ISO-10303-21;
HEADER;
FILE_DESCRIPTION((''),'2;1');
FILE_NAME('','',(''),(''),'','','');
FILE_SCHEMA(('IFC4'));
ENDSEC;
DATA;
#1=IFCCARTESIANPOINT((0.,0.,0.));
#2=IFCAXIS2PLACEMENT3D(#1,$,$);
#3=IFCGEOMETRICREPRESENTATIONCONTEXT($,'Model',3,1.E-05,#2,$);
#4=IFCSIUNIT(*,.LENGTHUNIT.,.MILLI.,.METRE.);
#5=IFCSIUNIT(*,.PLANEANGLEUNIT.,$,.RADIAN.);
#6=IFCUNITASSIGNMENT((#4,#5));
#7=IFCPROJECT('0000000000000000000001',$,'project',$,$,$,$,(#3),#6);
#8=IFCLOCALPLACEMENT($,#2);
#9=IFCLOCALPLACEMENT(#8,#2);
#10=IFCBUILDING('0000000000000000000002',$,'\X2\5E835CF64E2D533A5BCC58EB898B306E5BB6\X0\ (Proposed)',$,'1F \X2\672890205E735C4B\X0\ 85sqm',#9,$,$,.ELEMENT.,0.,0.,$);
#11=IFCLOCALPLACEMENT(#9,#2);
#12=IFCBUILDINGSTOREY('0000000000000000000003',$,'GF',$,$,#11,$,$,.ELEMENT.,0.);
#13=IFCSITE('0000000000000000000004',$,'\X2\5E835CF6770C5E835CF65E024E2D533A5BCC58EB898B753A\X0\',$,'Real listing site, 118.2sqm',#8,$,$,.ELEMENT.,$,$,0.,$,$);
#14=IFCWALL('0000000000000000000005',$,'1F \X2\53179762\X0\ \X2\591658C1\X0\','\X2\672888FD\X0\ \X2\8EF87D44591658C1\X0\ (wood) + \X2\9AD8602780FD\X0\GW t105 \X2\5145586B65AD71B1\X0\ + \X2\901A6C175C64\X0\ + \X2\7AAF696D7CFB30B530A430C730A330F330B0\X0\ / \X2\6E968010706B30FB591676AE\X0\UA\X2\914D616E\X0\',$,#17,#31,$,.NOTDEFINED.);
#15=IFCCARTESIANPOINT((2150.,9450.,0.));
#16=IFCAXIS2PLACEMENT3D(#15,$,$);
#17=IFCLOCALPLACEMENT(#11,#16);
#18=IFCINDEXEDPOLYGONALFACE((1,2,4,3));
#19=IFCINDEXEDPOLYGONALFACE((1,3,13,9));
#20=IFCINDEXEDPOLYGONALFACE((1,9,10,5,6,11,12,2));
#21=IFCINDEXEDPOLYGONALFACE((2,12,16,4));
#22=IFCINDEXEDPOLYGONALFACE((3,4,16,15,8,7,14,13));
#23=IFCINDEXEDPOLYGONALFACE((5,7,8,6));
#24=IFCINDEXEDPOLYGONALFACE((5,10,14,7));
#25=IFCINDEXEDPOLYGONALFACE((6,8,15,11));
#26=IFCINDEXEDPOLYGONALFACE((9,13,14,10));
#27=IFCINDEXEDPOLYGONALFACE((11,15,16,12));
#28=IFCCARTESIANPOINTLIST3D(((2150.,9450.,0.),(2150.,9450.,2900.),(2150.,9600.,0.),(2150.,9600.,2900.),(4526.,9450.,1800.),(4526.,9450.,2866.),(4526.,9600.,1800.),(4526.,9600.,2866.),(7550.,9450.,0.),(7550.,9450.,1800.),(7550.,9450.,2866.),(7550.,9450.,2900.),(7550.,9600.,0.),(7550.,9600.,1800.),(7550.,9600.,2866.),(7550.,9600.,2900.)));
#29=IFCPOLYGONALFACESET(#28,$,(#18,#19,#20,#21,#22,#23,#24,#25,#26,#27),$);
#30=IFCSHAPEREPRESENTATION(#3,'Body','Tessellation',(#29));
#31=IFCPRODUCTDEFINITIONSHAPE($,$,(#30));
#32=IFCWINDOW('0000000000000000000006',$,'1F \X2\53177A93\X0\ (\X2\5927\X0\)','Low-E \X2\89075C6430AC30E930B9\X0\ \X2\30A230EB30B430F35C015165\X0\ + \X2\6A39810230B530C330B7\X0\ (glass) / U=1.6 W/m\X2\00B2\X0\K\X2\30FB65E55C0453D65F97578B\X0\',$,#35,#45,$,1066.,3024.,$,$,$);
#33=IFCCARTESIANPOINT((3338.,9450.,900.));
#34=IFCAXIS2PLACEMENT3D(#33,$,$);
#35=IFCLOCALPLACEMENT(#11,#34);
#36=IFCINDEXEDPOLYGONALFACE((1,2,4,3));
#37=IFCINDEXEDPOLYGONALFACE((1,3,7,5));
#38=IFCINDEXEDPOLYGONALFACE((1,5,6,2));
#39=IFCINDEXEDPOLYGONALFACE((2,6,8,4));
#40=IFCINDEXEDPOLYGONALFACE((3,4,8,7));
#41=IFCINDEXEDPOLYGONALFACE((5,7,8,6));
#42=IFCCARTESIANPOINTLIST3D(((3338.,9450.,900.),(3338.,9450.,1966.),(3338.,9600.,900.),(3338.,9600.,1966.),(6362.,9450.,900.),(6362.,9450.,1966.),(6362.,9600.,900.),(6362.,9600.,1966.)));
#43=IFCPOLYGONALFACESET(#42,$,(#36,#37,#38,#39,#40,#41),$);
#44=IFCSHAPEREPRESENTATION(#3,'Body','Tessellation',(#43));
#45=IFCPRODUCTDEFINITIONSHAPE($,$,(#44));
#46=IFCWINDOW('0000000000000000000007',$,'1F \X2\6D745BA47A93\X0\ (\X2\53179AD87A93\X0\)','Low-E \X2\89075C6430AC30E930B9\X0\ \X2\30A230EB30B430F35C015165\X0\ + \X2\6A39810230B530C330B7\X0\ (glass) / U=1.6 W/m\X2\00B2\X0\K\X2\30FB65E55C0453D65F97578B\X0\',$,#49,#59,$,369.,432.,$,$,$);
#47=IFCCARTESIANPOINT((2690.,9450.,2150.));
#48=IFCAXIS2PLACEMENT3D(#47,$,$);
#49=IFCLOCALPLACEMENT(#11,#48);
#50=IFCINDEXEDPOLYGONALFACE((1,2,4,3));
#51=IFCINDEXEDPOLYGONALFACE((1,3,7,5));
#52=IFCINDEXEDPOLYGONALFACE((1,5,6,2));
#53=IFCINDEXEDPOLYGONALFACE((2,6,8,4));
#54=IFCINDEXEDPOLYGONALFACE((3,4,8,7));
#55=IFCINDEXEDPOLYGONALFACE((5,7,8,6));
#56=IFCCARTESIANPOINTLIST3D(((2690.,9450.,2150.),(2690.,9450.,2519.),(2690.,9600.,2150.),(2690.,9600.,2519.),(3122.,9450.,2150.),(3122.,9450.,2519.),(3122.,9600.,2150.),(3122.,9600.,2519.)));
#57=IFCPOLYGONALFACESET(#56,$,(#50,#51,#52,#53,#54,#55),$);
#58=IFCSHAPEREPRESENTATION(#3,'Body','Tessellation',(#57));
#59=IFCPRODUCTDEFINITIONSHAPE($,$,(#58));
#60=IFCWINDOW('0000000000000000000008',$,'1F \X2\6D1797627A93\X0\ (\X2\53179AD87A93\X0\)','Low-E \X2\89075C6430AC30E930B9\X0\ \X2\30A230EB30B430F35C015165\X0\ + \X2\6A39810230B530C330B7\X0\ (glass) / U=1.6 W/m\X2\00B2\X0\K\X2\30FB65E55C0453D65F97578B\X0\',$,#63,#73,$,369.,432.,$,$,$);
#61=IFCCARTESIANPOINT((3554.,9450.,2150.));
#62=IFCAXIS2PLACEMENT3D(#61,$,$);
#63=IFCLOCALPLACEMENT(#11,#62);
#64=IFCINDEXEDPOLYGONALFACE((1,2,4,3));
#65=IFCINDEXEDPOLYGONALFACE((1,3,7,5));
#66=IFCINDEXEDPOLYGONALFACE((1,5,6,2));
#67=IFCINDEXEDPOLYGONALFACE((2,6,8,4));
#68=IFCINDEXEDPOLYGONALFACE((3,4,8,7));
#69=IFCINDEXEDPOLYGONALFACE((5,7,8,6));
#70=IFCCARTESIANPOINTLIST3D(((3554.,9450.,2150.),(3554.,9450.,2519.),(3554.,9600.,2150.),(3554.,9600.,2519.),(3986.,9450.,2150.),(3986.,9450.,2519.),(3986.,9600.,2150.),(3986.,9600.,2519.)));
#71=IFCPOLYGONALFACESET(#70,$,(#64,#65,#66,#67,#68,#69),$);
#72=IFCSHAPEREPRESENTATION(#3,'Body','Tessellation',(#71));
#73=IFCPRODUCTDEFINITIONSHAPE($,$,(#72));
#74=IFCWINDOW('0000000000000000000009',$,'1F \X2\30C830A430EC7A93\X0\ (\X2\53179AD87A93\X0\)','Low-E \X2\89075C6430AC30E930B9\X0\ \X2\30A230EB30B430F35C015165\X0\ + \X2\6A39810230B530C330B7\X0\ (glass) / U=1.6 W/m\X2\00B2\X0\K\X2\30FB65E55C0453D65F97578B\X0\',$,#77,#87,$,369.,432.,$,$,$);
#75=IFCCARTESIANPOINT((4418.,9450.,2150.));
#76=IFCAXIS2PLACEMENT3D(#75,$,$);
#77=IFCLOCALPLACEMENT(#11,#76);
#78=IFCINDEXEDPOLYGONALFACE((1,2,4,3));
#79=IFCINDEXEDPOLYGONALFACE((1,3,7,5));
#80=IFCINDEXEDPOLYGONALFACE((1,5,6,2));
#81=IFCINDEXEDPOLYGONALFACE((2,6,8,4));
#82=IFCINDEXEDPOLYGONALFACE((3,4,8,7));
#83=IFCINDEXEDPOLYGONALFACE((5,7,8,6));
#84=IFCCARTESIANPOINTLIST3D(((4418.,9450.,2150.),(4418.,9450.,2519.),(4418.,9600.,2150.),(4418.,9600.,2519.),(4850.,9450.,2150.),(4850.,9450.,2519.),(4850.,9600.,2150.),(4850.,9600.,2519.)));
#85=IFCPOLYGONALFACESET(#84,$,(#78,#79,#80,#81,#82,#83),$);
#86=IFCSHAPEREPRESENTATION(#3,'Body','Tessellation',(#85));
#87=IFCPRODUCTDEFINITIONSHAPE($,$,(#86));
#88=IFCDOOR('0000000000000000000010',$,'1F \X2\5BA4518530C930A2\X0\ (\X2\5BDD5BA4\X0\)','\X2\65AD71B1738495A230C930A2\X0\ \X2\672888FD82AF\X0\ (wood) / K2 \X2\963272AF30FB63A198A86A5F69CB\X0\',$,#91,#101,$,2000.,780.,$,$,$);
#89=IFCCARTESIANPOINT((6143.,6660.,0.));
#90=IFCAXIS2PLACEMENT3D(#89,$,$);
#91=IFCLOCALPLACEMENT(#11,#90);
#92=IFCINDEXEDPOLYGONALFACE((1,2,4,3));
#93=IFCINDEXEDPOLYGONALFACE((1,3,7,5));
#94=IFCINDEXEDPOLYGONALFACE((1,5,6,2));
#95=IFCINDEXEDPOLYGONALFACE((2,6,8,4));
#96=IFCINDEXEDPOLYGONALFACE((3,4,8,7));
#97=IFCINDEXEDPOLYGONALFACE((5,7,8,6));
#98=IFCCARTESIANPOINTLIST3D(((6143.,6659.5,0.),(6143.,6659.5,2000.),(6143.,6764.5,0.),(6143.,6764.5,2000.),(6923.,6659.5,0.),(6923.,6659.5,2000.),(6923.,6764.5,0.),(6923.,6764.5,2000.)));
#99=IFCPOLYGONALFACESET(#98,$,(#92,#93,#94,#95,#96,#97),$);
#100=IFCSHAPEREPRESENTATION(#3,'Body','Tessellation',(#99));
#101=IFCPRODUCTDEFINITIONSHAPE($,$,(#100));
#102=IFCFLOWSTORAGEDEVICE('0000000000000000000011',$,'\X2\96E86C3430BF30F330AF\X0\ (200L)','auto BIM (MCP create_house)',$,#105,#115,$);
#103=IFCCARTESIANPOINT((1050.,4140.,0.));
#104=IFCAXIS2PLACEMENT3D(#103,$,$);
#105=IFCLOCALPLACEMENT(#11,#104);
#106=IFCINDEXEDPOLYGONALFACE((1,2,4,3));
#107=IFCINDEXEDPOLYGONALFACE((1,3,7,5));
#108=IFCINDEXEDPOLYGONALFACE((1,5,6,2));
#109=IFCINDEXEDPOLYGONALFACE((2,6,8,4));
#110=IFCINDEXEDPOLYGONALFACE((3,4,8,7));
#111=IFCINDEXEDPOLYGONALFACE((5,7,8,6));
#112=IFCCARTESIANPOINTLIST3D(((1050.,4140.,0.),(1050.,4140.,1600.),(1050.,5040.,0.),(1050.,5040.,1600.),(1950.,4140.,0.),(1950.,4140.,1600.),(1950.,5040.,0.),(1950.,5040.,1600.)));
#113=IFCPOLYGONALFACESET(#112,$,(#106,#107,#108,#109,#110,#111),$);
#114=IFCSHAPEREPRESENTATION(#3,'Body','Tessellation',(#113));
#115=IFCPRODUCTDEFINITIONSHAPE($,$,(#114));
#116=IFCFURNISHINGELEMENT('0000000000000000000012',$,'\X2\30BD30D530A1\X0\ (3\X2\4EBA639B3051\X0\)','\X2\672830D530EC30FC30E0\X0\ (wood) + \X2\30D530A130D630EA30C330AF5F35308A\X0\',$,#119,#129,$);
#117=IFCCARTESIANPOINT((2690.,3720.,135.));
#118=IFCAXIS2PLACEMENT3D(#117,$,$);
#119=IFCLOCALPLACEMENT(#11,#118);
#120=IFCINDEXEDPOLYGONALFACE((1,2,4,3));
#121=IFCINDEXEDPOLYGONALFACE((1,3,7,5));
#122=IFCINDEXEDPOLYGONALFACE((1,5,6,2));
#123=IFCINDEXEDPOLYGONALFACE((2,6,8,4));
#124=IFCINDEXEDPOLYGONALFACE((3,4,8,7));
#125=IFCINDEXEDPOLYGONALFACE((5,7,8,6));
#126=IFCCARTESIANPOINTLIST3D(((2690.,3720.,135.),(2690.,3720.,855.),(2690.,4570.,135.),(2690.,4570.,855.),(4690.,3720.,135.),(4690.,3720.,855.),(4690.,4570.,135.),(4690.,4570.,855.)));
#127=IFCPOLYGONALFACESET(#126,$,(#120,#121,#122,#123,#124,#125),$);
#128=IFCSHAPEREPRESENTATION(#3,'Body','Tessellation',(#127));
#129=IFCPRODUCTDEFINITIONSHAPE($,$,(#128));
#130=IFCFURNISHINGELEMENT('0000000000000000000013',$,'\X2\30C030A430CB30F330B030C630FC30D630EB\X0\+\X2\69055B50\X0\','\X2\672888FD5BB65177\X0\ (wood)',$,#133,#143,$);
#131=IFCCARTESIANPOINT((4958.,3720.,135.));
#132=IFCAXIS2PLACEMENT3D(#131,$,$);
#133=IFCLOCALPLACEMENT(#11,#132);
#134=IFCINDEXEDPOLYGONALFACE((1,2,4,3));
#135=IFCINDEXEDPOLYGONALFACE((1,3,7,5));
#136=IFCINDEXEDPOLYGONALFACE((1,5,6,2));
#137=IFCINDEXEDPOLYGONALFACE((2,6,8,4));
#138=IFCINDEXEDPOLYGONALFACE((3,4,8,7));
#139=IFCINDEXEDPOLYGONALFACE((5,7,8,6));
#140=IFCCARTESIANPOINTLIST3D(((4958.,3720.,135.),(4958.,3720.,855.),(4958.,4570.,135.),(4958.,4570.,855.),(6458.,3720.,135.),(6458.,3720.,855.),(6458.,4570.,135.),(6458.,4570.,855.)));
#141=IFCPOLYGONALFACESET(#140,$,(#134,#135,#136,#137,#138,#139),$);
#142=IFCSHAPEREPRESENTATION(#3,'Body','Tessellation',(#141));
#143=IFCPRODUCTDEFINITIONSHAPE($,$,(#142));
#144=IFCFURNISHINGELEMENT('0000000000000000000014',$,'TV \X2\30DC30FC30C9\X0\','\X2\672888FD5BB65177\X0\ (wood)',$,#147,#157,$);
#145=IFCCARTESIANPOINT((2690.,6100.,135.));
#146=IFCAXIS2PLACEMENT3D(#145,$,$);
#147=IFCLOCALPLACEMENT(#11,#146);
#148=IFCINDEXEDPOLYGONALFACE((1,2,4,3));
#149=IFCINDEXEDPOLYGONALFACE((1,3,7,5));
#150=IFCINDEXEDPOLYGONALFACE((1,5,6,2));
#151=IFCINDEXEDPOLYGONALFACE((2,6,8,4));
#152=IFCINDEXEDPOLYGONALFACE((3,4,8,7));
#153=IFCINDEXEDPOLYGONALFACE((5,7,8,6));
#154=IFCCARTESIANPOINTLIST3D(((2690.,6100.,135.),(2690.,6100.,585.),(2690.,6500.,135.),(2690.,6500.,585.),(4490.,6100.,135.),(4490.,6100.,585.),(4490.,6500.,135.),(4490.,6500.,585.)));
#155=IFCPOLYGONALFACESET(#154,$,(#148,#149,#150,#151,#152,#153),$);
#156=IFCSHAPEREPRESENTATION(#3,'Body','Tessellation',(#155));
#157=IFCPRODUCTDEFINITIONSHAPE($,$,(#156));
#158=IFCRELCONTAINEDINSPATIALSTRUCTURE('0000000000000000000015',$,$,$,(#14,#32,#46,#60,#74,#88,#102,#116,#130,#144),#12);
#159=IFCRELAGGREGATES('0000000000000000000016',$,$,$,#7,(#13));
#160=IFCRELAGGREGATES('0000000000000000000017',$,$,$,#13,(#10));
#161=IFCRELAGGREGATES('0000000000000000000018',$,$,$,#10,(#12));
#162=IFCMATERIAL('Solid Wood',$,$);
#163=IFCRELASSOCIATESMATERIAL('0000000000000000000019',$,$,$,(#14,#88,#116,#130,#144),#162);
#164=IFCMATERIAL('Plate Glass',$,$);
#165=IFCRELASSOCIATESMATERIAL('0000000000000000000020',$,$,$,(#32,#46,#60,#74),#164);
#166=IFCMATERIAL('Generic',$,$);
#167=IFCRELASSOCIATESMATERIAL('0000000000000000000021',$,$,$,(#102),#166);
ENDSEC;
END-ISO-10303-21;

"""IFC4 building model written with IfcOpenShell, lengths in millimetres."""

from ifc_helpers import new_model, si_unit, frame, frame_2d, origin, place, context, project, spatial, rectangle, extrude, material, element, fill, save


model = new_model("IFC4")

# Units and contexts
model_context = context("Model", 3, precision=1e-05, world=origin())
ifc_project = project(units=[si_unit("LENGTHUNIT", "METRE", prefix="MILLI"), si_unit("PLANEANGLEUNIT", "RADIAN")], contexts=[model_context])

# Site, building, storey
site_placement = place(None, origin())
site = spatial("IfcSite", under=ifc_project, at=site_placement, Name="広島県広島市中区富士見町", ObjectType="Real listing site, 118.2sqm", CompositionType="ELEMENT", RefElevation=0.0)
building_placement = place(site_placement, origin())
building = spatial("IfcBuilding", under=site, at=building_placement, Name="広島中区富士見の家 (Proposed)", ObjectType="1F 木造平屋 85sqm", CompositionType="ELEMENT", ElevationOfRefHeight=0.0, ElevationOfTerrain=0.0)
storey_placement = place(building_placement, origin())
storey = spatial("IfcBuildingStorey", under=building, at=storey_placement, Name="GF", CompositionType="ELEMENT", Elevation=0.0)

# Wall, openings, windows
ifc_material_1 = material(Name="Solid Wood")
wall_1_placement = place(storey_placement, frame((2150.0, 9450.0, 0.0)))
wall_1 = element("IfcWall", 1, at=wall_1_placement, inside=storey, material=ifc_material_1, Name="1F 北面 外壁", Description="木製 軸組外壁 (wood) + 高性能GW t105 充填断熱 + 通気層 + 窯業系サイディング / 準耐火・外皮UA配慮", PredefinedType="NOTDEFINED", context=model_context, shape_type="SweptSolid", body=[
    extrude(rectangle(XDim=5400.0, YDim=150.0, at=frame_2d((2700.0, 75.0))), frame((2150.0, 9450.0, 0.0)), (0.0, 0.0, 1.0), 2900.0),
])
opening_1_placement = place(storey_placement, frame((3338.0, 9450.0, 900.0)))
opening_1 = element("IfcOpeningElement", 2, at=opening_1_placement, cuts=wall_1, PredefinedType="NOTDEFINED", context=model_context, shape_type="SweptSolid", body=[
    extrude(rectangle(XDim=3024.0, YDim=150.0, at=frame_2d((1512.0, 75.0))), frame((3338.0, 9450.0, 900.0)), (0.0, 0.0, 1.0), 1066.0),
])
opening_2_placement = place(storey_placement, frame((2690.0, 9450.0, 2150.0)))
opening_2 = element("IfcOpeningElement", 3, at=opening_2_placement, cuts=wall_1, PredefinedType="NOTDEFINED", context=model_context, shape_type="SweptSolid", body=[
    extrude(rectangle(XDim=432.0, YDim=150.0, at=frame_2d((216.0, 75.0))), frame((2690.0, 9450.0, 2150.0)), (0.0, 0.0, 1.0), 369.0),
])
opening_3_placement = place(storey_placement, frame((3554.0, 9450.0, 2150.0)))
opening_3 = element("IfcOpeningElement", 4, at=opening_3_placement, cuts=wall_1, PredefinedType="NOTDEFINED", context=model_context, shape_type="SweptSolid", body=[
    extrude(rectangle(XDim=432.0, YDim=150.0, at=frame_2d((216.0, 75.0))), frame((3554.0, 9450.0, 2150.0)), (0.0, 0.0, 1.0), 369.0),
])
opening_4_placement = place(storey_placement, frame((4418.0, 9450.0, 2150.0)))
opening_4 = element("IfcOpeningElement", 5, at=opening_4_placement, cuts=wall_1, PredefinedType="NOTDEFINED", context=model_context, shape_type="SweptSolid", body=[
    extrude(rectangle(XDim=432.0, YDim=150.0, at=frame_2d((216.0, 75.0))), frame((4418.0, 9450.0, 2150.0)), (0.0, 0.0, 1.0), 369.0),
])
ifc_material_2 = material(Name="Plate Glass")
window_1_placement = place(storey_placement, frame((3338.0, 9450.0, 900.0)))
window_1 = element("IfcWindow", 6, at=window_1_placement, inside=storey, material=ifc_material_2, Name="1F 北窓 (大)", Description="Low-E 複層ガラス アルゴン封入 + 樹脂サッシ (glass) / U=1.6 W/m²K・日射取得型", OverallHeight=1066.0, OverallWidth=3024.0, context=model_context, shape_type="SweptSolid", body=[
    extrude(rectangle(XDim=3024.0, YDim=150.0, at=frame_2d((1512.0, 75.0))), frame((3338.0, 9450.0, 900.0)), (0.0, 0.0, 1.0), 1066.0),
])
fill(opening_1, window_1)
window_2_placement = place(storey_placement, frame((2690.0, 9450.0, 2150.0)))
window_2 = element("IfcWindow", 7, at=window_2_placement, inside=storey, material=ifc_material_2, Name="1F 浴室窓 (北高窓)", Description="Low-E 複層ガラス アルゴン封入 + 樹脂サッシ (glass) / U=1.6 W/m²K・日射取得型", OverallHeight=369.0, OverallWidth=432.0, context=model_context, shape_type="SweptSolid", body=[
    extrude(rectangle(XDim=432.0, YDim=150.0, at=frame_2d((216.0, 75.0))), frame((2690.0, 9450.0, 2150.0)), (0.0, 0.0, 1.0), 369.0),
])
fill(opening_2, window_2)
window_3_placement = place(storey_placement, frame((3554.0, 9450.0, 2150.0)))
window_3 = element("IfcWindow", 8, at=window_3_placement, inside=storey, material=ifc_material_2, Name="1F 洗面窓 (北高窓)", Description="Low-E 複層ガラス アルゴン封入 + 樹脂サッシ (glass) / U=1.6 W/m²K・日射取得型", OverallHeight=369.0, OverallWidth=432.0, context=model_context, shape_type="SweptSolid", body=[
    extrude(rectangle(XDim=432.0, YDim=150.0, at=frame_2d((216.0, 75.0))), frame((3554.0, 9450.0, 2150.0)), (0.0, 0.0, 1.0), 369.0),
])
fill(opening_3, window_3)
window_4_placement = place(storey_placement, frame((4418.0, 9450.0, 2150.0)))
window_4 = element("IfcWindow", 9, at=window_4_placement, inside=storey, material=ifc_material_2, Name="1F トイレ窓 (北高窓)", Description="Low-E 複層ガラス アルゴン封入 + 樹脂サッシ (glass) / U=1.6 W/m²K・日射取得型", OverallHeight=369.0, OverallWidth=432.0, context=model_context, shape_type="SweptSolid", body=[
    extrude(rectangle(XDim=432.0, YDim=150.0, at=frame_2d((216.0, 75.0))), frame((4418.0, 9450.0, 2150.0)), (0.0, 0.0, 1.0), 369.0),
])
fill(opening_4, window_4)

# Door
door_1_placement = place(storey_placement, frame((6143.0, 6660.0, 0.0)))
element("IfcDoor", 10, at=door_1_placement, inside=storey, material=ifc_material_1, Name="1F 室内ドア (寝室)", Description="断熱玄関ドア 木製芯 (wood) / K2 防犯・採風機構", OverallHeight=2000.0, OverallWidth=780.0, context=model_context, shape_type="SweptSolid", body=[
    extrude(rectangle(XDim=780.0, YDim=105.0, at=frame_2d((390.0, 52.0))), frame((6143.0, 6660.0, 0.0)), (0.0, 0.0, 1.0), 2000.0),
])

# Flow storage device
ifc_material_3 = material(Name="Generic")
flow_storage_device_placement = place(storey_placement, frame((1050.0, 4140.0, 0.0)))
element("IfcFlowStorageDevice", 11, at=flow_storage_device_placement, inside=storey, material=ifc_material_3, Name="雨水タンク (200L)", Description="auto BIM (MCP create_house)", context=model_context, shape_type="SweptSolid", body=[
    extrude(rectangle(XDim=900.0, YDim=900.0, at=frame_2d((450.0, 450.0))), frame((1050.0, 4140.0, 0.0)), (0.0, 0.0, 1.0), 1600.0),
])

# Furnishing elements
furnishing_1_placement = place(storey_placement, frame((2690.0, 3720.0, 135.0)))
element("IfcFurnishingElement", 12, at=furnishing_1_placement, inside=storey, material=ifc_material_1, Name="ソファ (3人掛け)", Description="木フレーム (wood) + ファブリック張り", context=model_context, shape_type="SweptSolid", body=[
    extrude(rectangle(XDim=2000.0, YDim=850.0, at=frame_2d((1000.0, 425.0))), frame((2690.0, 3720.0, 135.0)), (0.0, 0.0, 1.0), 720.0),
])
furnishing_2_placement = place(storey_placement, frame((4958.0, 3720.0, 135.0)))
element("IfcFurnishingElement", 13, at=furnishing_2_placement, inside=storey, material=ifc_material_1, Name="ダイニングテーブル+椅子", Description="木製家具 (wood)", context=model_context, shape_type="SweptSolid", body=[
    extrude(rectangle(XDim=1500.0, YDim=850.0, at=frame_2d((750.0, 425.0))), frame((4958.0, 3720.0, 135.0)), (0.0, 0.0, 1.0), 720.0),
])
furnishing_3_placement = place(storey_placement, frame((2690.0, 6100.0, 135.0)))
element("IfcFurnishingElement", 14, at=furnishing_3_placement, inside=storey, material=ifc_material_1, Name="TV ボード", Description="木製家具 (wood)", context=model_context, shape_type="SweptSolid", body=[
    extrude(rectangle(XDim=1800.0, YDim=400.0, at=frame_2d((900.0, 200.0))), frame((2690.0, 6100.0, 135.0)), (0.0, 0.0, 1.0), 450.0),
])

save(model, "model.ifc")
